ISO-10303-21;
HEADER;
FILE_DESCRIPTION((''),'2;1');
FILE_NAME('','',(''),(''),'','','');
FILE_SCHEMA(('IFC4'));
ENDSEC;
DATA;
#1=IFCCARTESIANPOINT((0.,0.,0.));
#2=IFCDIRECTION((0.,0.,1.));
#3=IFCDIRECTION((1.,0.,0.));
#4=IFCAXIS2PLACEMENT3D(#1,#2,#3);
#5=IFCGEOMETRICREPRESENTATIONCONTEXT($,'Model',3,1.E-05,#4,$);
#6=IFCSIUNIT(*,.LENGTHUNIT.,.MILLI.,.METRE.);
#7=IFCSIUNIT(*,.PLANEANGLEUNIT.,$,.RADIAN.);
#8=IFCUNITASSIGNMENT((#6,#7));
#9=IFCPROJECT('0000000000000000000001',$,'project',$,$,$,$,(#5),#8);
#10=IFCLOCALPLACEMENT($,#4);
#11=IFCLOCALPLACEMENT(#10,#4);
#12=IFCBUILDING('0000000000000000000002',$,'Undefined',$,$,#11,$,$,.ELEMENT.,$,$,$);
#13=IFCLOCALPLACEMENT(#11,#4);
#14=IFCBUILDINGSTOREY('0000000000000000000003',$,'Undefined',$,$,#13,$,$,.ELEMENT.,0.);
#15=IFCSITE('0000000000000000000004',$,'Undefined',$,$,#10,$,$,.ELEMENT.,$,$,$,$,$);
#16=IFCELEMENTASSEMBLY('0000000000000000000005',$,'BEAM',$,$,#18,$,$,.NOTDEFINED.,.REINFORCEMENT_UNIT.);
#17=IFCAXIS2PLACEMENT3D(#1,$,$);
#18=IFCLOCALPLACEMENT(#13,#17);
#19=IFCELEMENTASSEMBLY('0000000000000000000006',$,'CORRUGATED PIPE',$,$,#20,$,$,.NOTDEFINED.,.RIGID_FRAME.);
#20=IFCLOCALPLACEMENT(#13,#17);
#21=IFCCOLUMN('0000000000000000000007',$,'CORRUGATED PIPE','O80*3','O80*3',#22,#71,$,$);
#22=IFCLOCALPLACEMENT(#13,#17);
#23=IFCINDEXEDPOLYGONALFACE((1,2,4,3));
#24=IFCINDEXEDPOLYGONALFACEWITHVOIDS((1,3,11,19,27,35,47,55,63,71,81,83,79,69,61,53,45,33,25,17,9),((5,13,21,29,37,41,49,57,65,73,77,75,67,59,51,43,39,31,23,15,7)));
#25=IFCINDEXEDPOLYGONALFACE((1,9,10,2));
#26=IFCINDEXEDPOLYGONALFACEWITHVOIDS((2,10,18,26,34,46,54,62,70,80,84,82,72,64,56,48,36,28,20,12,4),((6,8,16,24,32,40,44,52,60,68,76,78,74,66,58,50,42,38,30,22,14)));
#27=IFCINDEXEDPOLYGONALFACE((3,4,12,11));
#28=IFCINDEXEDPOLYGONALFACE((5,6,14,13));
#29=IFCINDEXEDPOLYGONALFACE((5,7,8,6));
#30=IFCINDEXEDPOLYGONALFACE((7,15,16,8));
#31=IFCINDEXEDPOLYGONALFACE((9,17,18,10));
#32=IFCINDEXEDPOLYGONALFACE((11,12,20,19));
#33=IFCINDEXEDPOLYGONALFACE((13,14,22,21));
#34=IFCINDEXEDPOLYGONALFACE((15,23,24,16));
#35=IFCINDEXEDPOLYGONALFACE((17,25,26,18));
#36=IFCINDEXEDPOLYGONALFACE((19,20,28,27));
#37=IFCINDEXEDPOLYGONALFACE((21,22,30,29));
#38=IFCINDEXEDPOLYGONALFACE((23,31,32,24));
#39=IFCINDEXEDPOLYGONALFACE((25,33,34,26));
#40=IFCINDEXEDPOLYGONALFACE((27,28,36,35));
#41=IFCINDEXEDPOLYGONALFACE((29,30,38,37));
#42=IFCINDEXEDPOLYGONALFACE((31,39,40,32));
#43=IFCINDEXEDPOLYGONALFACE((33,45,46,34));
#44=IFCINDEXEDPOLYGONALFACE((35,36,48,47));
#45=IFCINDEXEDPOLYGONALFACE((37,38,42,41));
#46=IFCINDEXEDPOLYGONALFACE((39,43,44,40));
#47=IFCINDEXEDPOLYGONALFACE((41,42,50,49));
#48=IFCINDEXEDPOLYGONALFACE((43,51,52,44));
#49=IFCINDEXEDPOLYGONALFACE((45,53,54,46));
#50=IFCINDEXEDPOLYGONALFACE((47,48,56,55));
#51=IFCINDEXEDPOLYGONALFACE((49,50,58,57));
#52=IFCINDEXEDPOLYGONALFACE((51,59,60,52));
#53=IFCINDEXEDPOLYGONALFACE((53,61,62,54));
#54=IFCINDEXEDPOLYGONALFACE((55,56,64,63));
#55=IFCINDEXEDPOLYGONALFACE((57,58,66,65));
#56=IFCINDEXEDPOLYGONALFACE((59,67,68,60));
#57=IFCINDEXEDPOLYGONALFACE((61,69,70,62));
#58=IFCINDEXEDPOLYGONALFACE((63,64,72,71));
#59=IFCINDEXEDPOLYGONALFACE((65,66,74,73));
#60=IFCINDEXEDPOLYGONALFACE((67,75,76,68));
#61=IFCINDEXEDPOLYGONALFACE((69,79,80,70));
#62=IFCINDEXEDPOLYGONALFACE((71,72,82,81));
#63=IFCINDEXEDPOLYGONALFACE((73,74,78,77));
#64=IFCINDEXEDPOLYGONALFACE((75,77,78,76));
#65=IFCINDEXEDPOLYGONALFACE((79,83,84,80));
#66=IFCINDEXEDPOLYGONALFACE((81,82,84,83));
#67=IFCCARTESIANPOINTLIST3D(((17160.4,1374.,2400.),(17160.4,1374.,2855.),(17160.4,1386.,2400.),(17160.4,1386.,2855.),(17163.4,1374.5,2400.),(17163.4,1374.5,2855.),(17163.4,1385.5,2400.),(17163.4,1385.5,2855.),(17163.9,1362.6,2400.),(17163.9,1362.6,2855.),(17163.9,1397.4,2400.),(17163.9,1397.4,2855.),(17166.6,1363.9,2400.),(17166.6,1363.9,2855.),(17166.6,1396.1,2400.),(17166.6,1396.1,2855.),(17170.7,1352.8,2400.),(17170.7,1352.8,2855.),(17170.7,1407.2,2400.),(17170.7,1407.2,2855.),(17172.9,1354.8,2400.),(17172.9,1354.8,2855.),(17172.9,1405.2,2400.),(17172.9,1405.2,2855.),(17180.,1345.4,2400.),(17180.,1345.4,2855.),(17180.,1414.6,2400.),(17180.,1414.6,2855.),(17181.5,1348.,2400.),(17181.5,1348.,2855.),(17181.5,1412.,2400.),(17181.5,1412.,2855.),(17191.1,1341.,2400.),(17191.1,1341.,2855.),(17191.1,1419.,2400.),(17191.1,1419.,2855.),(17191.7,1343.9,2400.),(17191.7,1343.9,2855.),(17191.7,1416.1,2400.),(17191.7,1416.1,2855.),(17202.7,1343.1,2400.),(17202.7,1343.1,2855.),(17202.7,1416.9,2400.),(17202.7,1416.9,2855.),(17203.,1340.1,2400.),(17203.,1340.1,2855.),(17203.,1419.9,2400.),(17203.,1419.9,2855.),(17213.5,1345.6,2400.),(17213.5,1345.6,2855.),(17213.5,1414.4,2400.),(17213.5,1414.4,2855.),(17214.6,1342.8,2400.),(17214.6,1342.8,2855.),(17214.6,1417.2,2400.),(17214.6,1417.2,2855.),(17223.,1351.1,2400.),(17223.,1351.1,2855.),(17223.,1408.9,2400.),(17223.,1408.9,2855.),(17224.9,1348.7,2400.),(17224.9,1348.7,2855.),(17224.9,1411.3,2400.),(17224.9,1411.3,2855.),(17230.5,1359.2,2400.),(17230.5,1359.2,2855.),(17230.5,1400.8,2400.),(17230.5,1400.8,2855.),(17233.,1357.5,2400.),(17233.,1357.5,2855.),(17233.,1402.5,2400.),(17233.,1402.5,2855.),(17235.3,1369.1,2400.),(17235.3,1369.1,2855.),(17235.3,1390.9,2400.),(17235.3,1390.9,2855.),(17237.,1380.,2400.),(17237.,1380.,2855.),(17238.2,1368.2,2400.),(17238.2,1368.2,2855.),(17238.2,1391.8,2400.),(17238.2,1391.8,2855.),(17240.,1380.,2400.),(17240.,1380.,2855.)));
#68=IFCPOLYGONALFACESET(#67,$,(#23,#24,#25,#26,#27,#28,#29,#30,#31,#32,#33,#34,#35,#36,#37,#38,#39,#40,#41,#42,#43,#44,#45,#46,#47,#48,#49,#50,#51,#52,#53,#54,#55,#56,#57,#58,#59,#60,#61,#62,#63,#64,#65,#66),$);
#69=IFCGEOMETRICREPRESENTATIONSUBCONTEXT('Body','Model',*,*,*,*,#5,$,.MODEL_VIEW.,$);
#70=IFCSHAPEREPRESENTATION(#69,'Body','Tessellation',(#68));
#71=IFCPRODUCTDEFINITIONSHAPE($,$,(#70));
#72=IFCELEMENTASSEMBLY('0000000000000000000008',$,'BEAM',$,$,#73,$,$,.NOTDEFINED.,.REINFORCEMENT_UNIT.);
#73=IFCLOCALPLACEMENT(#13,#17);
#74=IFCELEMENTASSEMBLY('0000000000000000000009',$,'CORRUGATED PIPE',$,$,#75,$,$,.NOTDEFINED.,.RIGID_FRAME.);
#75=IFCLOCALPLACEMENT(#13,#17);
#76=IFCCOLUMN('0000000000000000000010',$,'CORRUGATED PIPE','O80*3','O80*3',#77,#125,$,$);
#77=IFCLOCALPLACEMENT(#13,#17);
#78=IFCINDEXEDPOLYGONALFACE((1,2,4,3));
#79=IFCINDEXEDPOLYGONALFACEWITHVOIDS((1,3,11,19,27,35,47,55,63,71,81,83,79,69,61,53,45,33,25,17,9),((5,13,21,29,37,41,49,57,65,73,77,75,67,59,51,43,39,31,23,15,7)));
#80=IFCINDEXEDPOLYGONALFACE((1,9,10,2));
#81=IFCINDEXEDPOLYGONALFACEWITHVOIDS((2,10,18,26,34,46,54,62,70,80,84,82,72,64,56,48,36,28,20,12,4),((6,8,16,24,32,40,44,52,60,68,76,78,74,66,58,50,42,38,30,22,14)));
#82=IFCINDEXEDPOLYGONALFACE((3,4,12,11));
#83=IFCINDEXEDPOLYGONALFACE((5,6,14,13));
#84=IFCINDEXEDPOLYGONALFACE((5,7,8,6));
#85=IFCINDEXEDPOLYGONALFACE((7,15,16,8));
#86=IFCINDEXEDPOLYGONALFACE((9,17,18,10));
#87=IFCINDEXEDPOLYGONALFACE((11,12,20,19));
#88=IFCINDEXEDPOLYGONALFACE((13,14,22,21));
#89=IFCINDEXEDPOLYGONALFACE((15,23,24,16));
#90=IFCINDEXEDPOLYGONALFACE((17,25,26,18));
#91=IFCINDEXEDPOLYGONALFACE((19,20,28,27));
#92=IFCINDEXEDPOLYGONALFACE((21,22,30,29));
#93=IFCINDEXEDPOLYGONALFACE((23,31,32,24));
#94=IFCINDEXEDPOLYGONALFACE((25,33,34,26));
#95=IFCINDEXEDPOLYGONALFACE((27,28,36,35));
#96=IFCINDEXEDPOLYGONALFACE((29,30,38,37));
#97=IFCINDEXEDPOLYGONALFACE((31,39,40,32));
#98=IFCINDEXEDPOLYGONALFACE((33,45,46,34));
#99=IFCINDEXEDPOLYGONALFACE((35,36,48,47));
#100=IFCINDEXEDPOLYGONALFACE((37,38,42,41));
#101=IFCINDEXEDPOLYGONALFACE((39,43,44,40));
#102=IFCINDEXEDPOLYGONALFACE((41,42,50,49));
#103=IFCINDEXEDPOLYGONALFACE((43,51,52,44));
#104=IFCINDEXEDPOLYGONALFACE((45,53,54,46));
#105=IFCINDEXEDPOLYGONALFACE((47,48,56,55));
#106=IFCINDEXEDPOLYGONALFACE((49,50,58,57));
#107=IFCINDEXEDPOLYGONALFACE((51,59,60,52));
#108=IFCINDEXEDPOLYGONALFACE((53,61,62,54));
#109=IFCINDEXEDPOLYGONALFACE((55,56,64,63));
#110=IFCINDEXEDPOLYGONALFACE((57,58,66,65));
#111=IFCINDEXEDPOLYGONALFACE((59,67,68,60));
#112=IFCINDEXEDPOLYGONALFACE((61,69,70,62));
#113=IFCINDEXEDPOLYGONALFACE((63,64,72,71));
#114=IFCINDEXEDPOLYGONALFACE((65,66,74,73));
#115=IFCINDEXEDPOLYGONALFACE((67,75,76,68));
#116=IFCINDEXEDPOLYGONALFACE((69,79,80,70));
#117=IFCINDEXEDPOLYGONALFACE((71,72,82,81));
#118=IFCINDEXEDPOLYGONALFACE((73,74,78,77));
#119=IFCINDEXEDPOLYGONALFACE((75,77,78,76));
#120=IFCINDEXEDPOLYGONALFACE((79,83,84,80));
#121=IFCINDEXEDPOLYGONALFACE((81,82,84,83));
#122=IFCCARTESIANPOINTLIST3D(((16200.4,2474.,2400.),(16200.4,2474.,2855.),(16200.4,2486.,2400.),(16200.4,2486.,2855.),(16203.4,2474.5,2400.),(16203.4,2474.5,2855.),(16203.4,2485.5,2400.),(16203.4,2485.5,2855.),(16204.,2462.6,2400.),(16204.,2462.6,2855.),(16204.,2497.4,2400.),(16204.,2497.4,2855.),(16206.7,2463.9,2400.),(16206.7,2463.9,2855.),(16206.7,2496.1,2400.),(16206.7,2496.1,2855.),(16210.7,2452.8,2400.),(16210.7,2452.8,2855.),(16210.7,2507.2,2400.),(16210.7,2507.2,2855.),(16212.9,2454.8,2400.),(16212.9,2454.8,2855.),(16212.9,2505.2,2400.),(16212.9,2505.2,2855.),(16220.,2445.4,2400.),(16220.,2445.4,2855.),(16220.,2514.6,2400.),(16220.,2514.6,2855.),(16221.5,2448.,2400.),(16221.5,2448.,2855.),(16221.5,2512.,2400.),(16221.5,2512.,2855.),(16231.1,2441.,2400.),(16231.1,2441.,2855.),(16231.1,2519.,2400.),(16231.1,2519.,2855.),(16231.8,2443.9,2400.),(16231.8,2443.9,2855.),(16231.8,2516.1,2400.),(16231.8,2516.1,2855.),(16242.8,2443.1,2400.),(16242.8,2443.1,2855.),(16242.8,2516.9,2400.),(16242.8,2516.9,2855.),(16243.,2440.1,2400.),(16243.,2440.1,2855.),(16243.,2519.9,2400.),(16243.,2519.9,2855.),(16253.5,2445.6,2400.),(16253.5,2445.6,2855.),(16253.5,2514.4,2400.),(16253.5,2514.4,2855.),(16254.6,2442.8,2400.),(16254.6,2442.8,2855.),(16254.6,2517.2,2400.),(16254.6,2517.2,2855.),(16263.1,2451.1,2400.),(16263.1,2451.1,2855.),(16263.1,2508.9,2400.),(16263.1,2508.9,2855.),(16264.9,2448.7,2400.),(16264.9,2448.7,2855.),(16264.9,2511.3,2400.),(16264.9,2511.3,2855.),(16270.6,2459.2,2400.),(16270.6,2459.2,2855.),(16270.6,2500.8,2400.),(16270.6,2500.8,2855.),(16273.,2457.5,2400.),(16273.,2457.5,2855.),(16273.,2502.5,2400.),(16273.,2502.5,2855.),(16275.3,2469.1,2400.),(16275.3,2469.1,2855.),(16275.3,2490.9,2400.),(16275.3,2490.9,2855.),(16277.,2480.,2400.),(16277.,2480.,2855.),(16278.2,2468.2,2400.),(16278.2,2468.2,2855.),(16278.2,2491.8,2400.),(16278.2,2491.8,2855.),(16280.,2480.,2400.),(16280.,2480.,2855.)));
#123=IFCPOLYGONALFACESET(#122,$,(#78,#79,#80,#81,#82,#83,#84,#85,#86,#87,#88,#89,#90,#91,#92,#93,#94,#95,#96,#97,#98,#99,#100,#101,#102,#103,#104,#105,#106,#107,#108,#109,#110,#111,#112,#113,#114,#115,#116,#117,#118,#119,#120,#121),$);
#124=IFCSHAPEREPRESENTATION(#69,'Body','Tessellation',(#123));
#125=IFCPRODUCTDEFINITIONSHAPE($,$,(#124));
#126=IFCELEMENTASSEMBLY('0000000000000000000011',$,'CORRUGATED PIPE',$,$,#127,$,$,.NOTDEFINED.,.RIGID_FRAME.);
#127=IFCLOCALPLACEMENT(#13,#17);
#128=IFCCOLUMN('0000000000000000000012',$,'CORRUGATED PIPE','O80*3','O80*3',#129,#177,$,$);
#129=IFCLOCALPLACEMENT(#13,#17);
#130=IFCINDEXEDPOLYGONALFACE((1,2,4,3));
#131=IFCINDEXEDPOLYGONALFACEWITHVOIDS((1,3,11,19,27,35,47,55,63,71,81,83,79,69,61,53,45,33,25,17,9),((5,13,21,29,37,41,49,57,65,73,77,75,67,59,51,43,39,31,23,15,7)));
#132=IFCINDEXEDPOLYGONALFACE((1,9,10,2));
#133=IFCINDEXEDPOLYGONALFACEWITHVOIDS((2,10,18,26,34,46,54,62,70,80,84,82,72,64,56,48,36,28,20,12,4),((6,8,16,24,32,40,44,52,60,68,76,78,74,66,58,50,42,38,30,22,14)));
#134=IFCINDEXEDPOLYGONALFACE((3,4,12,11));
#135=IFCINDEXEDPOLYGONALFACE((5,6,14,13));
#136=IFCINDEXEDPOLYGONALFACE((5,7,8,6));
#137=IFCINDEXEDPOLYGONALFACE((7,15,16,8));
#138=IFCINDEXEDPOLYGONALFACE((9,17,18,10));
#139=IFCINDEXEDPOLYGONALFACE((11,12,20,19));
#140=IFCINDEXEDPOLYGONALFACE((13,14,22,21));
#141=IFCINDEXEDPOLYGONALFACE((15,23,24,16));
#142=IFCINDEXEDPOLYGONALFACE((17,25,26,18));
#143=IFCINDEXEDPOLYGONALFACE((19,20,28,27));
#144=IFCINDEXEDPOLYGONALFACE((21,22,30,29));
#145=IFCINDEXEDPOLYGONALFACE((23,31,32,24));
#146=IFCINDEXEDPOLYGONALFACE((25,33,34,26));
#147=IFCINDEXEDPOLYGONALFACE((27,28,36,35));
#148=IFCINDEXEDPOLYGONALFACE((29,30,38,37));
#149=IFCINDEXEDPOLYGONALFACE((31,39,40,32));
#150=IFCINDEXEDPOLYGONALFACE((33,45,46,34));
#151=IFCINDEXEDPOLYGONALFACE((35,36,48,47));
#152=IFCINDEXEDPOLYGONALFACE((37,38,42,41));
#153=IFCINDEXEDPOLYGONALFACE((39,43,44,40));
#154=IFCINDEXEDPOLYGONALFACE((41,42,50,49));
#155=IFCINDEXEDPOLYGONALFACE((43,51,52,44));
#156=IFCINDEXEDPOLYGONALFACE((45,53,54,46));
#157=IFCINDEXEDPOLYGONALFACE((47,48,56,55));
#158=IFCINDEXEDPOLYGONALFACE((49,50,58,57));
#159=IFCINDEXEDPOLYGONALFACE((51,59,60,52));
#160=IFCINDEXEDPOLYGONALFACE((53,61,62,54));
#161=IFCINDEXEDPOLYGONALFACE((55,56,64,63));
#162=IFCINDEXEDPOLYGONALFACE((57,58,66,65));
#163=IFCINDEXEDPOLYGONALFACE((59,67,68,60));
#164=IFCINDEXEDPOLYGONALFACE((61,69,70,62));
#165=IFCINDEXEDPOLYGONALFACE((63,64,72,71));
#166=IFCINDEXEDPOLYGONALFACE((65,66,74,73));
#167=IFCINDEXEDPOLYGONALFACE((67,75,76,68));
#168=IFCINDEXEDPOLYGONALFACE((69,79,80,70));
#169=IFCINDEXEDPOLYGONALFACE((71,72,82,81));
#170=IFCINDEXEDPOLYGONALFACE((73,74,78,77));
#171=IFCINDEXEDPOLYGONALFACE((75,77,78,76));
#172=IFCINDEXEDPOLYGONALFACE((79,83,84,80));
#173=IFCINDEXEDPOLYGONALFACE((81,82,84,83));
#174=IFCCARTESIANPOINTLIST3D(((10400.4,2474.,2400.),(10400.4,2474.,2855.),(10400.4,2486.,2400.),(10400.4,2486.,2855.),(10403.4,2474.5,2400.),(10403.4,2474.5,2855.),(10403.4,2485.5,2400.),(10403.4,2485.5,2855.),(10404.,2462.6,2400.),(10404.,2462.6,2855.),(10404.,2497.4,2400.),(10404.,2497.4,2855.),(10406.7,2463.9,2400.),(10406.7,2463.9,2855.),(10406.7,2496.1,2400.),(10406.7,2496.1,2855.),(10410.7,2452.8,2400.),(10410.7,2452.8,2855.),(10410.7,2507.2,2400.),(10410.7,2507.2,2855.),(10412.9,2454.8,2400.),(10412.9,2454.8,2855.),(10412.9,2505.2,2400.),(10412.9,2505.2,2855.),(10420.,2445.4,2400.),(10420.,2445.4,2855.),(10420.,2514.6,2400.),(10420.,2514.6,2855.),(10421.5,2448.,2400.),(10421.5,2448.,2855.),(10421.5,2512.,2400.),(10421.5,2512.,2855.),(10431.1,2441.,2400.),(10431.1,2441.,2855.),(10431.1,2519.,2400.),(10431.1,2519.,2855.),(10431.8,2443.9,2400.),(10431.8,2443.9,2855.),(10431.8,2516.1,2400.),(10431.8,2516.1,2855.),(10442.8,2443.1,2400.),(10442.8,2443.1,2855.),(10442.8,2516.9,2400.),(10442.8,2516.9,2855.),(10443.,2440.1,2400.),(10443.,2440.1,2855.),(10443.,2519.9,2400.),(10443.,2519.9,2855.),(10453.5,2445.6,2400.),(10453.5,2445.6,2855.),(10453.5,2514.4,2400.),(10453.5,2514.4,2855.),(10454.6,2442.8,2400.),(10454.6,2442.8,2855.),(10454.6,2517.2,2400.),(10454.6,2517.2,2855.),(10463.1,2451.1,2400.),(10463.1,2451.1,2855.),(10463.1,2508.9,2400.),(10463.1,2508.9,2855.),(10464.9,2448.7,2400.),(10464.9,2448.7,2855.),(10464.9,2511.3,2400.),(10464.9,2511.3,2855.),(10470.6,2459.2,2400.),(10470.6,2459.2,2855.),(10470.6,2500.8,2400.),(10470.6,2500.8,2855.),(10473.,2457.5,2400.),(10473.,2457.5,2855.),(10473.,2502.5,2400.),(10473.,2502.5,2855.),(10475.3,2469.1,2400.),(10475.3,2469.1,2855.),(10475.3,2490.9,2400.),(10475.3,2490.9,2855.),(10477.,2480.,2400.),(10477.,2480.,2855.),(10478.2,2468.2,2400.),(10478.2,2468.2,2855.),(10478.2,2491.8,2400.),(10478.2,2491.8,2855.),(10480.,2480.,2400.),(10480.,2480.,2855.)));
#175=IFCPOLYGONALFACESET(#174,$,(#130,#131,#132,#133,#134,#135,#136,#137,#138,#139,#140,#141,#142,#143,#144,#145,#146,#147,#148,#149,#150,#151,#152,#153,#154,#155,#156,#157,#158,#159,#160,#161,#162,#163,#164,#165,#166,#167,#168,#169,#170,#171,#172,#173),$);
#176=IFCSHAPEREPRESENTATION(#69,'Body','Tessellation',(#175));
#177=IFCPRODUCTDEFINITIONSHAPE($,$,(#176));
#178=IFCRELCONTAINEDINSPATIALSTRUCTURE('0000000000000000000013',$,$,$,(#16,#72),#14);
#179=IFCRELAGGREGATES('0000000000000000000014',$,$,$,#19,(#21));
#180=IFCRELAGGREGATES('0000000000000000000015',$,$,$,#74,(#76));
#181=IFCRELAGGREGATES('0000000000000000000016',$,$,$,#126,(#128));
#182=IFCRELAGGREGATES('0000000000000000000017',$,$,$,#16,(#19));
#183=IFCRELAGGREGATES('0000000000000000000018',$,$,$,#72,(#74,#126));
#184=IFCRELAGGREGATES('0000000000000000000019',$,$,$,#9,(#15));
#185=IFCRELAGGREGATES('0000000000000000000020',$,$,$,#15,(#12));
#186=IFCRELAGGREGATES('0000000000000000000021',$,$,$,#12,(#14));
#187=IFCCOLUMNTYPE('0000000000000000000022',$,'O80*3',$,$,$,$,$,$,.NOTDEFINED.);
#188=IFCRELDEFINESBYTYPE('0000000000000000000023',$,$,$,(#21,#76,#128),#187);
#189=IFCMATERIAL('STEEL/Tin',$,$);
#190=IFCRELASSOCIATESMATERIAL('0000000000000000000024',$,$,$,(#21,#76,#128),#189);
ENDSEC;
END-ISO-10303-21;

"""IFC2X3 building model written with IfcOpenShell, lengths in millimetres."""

from ifc_helpers import new_model, si_unit, frame, origin_with_axes, origin_2d_with_axis, place, context, subcontext, project, spatial, hollow_circle, extrude, material, type_object, element, aggregate, save


model = new_model("IFC2X3")

# Units and contexts
model_context = context("Model", 3, precision=1e-05, world=origin_with_axes())
body_context = subcontext(model_context, "Body", "Model", "MODEL_VIEW")
ifc_project = project(units=[si_unit("LENGTHUNIT", "METRE", prefix="MILLI"), si_unit("PLANEANGLEUNIT", "RADIAN")], contexts=[model_context])

# Site, building, storey
site_placement = place(None, origin_with_axes())
site = spatial("IfcSite", under=ifc_project, at=site_placement, Name="Undefined", CompositionType="ELEMENT")
building_placement = place(site_placement, origin_with_axes())
building = spatial("IfcBuilding", under=site, at=building_placement, Name="Undefined", CompositionType="ELEMENT")
storey_placement = place(building_placement, origin_with_axes())
storey = spatial("IfcBuildingStorey", under=building, at=storey_placement, Name="Undefined", CompositionType="ELEMENT", Elevation=0.0)

# Element assemblies, column
assembly_1_placement = place(storey_placement, origin_with_axes())
assembly_1 = element("IfcElementAssembly", 1, at=assembly_1_placement, inside=storey, Name="BEAM", AssemblyPlace="NOTDEFINED", PredefinedType="REINFORCEMENT_UNIT")
assembly_2_placement = place(assembly_1_placement, origin_with_axes())
assembly_2 = element("IfcElementAssembly", 2, at=assembly_2_placement, Name="CORRUGATED PIPE", AssemblyPlace="NOTDEFINED", PredefinedType="RIGID_FRAME")
ifc_material_1 = material(Name="STEEL/Tin")
column_type = type_object("IfcColumnType", Name="O80*3", PredefinedType="NOTDEFINED")
column_1_placement = place(assembly_2_placement, frame((17200.0, 1380.0, 2400.0), z_axis=(0.0, 0.0, 1.0), x_axis=(0.0, -1.0, 0.0)))
column_1 = element("IfcColumn", 3, at=column_1_placement, type_object=column_type, material=ifc_material_1, Name="CORRUGATED PIPE", Description="O80*3", ObjectType="O80*3", context=body_context, shape_type="SweptSolid", body=[
    extrude(hollow_circle(Radius=40.0, WallThickness=3.0, at=origin_2d_with_axis()), frame((0.0, 0.0, 455.0), z_axis=(0.0, 0.0, -1.0), x_axis=(0.0, 1.0, 0.0)), (0.0, 0.0, 1.0), 455.0),
])
aggregate(assembly_2, [column_1])

# Element assemblies, columns
assembly_3_placement = place(storey_placement, origin_with_axes())
assembly_3 = element("IfcElementAssembly", 4, at=assembly_3_placement, inside=storey, Name="BEAM", AssemblyPlace="NOTDEFINED", PredefinedType="REINFORCEMENT_UNIT")
assembly_4_placement = place(assembly_3_placement, origin_with_axes())
assembly_4 = element("IfcElementAssembly", 5, at=assembly_4_placement, Name="CORRUGATED PIPE", AssemblyPlace="NOTDEFINED", PredefinedType="RIGID_FRAME")
column_2_placement = place(assembly_4_placement, frame((16240.0, 2480.0, 2400.0), z_axis=(0.0, 0.0, 1.0), x_axis=(0.0, -1.0, 0.0)))
column_2 = element("IfcColumn", 6, at=column_2_placement, type_object=column_type, material=ifc_material_1, Name="CORRUGATED PIPE", Description="O80*3", ObjectType="O80*3", context=body_context, shape_type="SweptSolid", body=[
    extrude(hollow_circle(Radius=40.0, WallThickness=3.0, at=origin_2d_with_axis()), frame((0.0, 0.0, 455.0), z_axis=(0.0, 0.0, -1.0), x_axis=(0.0, 1.0, 0.0)), (0.0, 0.0, 1.0), 455.0),
])
aggregate(assembly_4, [column_2])
assembly_5_placement = place(assembly_3_placement, origin_with_axes())
assembly_5 = element("IfcElementAssembly", 7, at=assembly_5_placement, Name="CORRUGATED PIPE", AssemblyPlace="NOTDEFINED", PredefinedType="RIGID_FRAME")
column_3_placement = place(assembly_5_placement, frame((10440.0, 2480.0, 2400.0), z_axis=(0.0, 0.0, 1.0), x_axis=(0.0, -1.0, 0.0)))
column_3 = element("IfcColumn", 8, at=column_3_placement, type_object=column_type, material=ifc_material_1, Name="CORRUGATED PIPE", Description="O80*3", ObjectType="O80*3", context=body_context, shape_type="SweptSolid", body=[
    extrude(hollow_circle(Radius=40.0, WallThickness=3.0, at=origin_2d_with_axis()), frame((0.0, 0.0, 455.0), z_axis=(0.0, 0.0, -1.0), x_axis=(0.0, 1.0, 0.0)), (0.0, 0.0, 1.0), 455.0),
])
aggregate(assembly_5, [column_3])

aggregate(assembly_1, [assembly_2])
aggregate(assembly_3, [assembly_4, assembly_5])

save(model, "model.ifc")
